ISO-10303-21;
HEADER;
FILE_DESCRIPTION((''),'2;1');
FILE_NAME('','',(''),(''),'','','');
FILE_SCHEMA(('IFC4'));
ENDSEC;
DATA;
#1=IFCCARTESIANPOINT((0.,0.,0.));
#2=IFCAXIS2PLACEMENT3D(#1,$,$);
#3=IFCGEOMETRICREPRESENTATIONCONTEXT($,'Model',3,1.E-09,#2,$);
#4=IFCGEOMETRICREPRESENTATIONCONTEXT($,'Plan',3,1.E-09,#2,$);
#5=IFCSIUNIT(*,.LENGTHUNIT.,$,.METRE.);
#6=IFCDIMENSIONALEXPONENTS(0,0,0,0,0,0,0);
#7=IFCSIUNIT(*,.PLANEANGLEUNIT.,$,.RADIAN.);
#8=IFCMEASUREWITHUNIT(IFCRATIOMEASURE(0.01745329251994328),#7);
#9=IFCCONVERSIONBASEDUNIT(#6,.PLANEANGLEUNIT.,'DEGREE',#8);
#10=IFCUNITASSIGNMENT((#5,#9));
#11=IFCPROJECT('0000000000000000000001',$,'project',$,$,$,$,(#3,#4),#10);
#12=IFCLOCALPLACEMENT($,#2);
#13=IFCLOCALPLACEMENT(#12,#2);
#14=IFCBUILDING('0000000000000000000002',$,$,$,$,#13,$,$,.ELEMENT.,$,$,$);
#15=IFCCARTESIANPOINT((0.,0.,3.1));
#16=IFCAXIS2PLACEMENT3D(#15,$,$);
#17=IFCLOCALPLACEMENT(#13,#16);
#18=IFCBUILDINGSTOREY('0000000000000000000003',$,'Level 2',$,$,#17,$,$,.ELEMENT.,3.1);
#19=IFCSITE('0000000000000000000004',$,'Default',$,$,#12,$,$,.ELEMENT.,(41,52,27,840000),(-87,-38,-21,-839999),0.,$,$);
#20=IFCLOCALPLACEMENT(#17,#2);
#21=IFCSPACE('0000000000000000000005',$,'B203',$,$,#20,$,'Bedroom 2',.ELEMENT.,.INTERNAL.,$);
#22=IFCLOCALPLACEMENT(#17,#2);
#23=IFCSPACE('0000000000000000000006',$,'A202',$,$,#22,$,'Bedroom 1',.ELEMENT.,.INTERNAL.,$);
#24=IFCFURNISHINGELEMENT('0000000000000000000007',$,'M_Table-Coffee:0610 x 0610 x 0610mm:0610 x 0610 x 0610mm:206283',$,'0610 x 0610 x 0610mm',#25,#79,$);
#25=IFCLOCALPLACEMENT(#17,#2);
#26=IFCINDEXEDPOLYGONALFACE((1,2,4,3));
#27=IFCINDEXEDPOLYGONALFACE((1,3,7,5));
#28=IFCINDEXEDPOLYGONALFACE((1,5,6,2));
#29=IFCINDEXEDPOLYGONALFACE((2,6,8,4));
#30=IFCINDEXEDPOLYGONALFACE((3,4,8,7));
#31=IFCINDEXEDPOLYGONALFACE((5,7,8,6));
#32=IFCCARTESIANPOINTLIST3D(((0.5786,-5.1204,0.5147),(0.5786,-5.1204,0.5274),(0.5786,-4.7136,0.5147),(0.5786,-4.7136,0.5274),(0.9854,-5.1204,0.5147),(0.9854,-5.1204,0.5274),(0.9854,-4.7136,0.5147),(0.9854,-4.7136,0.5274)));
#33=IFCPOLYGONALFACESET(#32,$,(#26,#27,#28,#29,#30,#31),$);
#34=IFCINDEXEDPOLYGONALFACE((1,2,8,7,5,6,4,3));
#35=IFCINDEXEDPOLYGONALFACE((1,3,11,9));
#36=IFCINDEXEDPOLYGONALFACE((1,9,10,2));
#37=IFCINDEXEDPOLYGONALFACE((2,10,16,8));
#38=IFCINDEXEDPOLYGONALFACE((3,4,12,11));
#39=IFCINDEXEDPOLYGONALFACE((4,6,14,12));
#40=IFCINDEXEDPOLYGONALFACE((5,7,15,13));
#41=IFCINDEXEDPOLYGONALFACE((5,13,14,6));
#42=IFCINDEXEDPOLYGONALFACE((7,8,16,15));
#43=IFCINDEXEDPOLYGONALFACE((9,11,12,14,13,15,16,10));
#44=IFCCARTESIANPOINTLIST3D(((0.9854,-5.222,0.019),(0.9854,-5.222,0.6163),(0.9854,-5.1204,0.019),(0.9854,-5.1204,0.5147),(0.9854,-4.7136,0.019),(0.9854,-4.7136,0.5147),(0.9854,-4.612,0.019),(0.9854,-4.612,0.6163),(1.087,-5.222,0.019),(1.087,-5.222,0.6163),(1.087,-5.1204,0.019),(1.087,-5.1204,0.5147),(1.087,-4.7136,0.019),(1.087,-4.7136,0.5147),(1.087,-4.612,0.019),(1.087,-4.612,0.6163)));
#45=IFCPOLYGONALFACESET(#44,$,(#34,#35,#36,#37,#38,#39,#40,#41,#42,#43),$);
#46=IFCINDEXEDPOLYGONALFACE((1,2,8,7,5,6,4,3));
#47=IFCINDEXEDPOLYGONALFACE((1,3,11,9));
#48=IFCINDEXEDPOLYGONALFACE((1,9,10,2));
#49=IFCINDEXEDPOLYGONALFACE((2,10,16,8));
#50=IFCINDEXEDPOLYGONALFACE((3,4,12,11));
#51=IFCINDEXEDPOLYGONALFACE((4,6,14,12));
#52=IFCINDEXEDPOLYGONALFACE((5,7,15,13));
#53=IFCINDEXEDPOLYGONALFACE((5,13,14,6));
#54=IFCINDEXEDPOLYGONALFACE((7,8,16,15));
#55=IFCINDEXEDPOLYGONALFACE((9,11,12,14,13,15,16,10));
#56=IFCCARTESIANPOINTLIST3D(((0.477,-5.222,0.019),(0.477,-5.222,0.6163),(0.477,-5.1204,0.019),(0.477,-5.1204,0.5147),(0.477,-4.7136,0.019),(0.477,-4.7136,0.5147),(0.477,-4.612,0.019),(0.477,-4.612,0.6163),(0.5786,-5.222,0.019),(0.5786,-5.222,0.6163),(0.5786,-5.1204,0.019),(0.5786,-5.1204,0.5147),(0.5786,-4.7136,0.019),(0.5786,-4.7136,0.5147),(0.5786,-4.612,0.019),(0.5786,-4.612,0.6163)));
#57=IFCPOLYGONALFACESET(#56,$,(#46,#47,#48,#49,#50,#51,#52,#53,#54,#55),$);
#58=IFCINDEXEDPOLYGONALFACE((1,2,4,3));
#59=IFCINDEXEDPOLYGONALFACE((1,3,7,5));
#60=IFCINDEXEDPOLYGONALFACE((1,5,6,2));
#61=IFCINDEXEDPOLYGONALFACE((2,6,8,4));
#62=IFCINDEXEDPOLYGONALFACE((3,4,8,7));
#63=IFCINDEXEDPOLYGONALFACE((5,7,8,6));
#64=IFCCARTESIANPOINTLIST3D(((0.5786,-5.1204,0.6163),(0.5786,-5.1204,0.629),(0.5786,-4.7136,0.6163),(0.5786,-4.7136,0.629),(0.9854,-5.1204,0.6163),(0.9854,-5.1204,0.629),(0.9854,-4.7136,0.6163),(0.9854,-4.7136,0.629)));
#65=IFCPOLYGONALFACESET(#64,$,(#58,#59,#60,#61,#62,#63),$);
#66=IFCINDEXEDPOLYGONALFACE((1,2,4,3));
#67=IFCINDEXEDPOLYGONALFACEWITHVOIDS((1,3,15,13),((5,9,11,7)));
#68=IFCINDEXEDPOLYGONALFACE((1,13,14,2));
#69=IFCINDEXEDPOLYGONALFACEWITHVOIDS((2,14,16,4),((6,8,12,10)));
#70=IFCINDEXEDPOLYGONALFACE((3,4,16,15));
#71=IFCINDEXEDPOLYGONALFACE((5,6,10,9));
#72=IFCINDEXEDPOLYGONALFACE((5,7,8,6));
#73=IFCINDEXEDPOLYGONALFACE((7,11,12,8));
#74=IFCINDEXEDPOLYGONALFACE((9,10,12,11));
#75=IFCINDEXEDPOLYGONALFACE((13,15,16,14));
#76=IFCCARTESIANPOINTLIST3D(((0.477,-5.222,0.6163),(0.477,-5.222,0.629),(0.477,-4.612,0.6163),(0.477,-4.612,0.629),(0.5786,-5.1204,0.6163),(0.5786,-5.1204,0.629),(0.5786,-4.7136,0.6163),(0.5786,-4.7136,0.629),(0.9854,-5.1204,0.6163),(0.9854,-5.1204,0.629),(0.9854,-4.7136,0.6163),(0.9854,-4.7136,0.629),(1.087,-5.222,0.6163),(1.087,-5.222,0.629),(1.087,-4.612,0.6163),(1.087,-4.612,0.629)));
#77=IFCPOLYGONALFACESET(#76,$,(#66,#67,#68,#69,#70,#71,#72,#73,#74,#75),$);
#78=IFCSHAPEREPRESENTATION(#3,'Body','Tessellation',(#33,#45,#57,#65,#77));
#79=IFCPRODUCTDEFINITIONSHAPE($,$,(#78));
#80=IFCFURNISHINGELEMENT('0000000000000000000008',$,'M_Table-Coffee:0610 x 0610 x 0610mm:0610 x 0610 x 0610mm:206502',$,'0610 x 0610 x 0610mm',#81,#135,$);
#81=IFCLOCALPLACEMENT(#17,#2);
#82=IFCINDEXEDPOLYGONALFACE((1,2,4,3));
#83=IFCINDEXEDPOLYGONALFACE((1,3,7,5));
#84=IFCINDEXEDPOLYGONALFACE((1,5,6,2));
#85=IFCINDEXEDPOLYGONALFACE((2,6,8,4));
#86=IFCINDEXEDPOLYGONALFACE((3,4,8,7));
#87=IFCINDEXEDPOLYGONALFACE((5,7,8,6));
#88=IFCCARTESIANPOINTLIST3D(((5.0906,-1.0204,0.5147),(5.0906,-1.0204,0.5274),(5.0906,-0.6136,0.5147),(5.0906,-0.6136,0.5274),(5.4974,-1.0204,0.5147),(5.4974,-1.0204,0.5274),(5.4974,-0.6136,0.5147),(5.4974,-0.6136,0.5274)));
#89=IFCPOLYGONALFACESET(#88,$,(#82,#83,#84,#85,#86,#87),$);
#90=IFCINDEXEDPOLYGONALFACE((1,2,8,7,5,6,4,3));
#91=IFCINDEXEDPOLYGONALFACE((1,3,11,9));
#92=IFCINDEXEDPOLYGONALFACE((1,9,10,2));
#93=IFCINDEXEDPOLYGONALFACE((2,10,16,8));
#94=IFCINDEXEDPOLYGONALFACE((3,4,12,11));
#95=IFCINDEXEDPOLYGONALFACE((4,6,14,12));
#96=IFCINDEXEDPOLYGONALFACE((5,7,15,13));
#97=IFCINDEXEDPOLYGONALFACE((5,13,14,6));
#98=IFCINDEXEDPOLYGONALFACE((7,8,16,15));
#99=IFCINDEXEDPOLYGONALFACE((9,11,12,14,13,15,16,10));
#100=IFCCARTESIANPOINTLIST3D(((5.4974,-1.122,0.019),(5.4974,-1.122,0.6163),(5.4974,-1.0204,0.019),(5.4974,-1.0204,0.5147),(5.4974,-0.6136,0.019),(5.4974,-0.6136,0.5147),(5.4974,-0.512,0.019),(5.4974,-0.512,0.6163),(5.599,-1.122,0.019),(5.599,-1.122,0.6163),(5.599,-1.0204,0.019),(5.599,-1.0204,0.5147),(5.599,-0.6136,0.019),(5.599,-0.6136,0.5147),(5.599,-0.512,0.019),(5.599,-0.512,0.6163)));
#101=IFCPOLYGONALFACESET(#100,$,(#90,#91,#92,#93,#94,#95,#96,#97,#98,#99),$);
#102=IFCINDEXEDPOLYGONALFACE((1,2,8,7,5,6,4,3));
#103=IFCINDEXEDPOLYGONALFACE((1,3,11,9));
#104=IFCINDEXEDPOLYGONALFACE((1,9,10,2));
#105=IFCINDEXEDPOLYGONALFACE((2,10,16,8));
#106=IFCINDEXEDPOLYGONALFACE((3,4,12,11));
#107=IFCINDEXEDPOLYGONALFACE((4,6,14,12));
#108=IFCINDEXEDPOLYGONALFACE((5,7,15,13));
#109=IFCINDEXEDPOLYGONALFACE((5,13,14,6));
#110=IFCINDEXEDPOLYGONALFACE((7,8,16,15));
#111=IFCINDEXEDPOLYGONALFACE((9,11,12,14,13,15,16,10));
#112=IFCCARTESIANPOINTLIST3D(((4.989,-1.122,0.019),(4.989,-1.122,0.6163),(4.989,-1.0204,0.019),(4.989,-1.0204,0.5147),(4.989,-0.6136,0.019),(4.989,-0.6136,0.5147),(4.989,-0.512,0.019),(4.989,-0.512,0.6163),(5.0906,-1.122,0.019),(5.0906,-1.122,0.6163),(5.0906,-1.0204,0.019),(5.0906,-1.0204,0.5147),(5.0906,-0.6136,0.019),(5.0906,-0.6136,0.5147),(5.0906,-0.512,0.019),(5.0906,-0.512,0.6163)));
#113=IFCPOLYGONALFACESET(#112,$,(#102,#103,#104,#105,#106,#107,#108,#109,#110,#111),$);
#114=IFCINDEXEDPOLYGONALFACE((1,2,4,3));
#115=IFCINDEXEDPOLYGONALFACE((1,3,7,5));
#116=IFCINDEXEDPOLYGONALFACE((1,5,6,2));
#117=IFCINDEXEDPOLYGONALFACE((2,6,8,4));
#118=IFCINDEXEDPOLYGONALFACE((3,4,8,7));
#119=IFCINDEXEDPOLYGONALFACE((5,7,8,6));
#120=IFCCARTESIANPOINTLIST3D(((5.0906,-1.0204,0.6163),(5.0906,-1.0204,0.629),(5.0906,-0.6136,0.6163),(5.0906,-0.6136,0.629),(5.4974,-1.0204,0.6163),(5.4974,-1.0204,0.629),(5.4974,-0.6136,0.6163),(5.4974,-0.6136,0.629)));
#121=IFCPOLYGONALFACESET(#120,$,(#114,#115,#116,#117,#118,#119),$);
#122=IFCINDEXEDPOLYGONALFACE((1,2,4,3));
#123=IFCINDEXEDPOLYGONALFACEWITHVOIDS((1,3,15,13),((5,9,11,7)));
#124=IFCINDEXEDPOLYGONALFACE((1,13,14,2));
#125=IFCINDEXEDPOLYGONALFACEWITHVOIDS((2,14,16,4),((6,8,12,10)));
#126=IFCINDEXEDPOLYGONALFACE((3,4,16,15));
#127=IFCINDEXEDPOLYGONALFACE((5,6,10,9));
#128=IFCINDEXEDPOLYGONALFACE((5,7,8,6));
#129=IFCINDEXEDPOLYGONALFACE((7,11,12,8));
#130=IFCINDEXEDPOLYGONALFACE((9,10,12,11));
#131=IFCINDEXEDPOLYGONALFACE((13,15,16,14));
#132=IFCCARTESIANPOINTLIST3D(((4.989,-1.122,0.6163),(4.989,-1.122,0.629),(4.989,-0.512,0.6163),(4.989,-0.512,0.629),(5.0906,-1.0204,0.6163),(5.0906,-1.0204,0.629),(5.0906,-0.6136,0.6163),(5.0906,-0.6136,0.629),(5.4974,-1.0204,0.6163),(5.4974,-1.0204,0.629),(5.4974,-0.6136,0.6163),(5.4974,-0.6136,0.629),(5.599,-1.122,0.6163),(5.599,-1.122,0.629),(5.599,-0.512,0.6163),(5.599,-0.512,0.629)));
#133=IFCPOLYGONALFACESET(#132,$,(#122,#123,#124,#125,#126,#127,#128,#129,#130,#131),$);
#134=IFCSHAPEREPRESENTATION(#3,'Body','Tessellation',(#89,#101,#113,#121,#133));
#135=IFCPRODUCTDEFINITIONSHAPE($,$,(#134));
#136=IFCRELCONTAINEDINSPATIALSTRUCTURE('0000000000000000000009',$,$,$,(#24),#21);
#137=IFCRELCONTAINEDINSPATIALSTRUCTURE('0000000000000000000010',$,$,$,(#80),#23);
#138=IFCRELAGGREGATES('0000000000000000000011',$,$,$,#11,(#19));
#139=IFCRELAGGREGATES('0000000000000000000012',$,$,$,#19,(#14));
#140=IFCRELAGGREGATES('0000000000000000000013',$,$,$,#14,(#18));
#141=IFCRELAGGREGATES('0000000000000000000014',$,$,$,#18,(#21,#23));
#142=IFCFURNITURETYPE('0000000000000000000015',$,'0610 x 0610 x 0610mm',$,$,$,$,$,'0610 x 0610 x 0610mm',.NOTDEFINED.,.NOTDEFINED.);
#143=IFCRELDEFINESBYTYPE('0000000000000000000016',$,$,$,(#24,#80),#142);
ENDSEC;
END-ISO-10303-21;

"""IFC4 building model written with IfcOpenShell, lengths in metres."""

from ifc_helpers import new_model, entity, si_unit, converted_unit, frame, origin, origin_2d_with_axis, place, context, project, spatial, polyline, rectangle, outline, extrude, source, transform, mapped, type_object, type_shapes, element, save


model = new_model("IFC4")

# Units and contexts
model_context = context("Model", 3, precision=1e-09, world=origin())
plan_context = context("Plan", 3, precision=1e-09, world=origin())
ifc_project = project(units=[si_unit("LENGTHUNIT", "METRE"), converted_unit("PLANEANGLEUNIT", "DEGREE", entity("IfcRatioMeasure", 0.01745329251994328), si_unit("PLANEANGLEUNIT", "RADIAN"), dimensions=[0, 0, 0, 0, 0, 0, 0])], contexts=[model_context, plan_context])

# Site, building, storey
site_placement = place(None, origin())
site = spatial("IfcSite", under=ifc_project, at=site_placement, Name="Default", CompositionType="ELEMENT", RefLatitude=(41, 52, 27, 840000), RefLongitude=(-87, -38, -21, -839999), RefElevation=0.0)
building_placement = place(site_placement, origin())
building = spatial("IfcBuilding", under=site, at=building_placement, CompositionType="ELEMENT")
storey_placement = place(building_placement, frame((0.0, 0.0, 3.1)))
storey = spatial("IfcBuildingStorey", under=building, at=storey_placement, Name="Level 2", CompositionType="ELEMENT", Elevation=3.1)

# Shared definitions
space_1_placement = place(storey_placement, origin())
space_1 = spatial("IfcSpace", under=storey, at=space_1_placement, Name="B203", LongName="Bedroom 2", CompositionType="ELEMENT", PredefinedType="INTERNAL")

# Furnishing element
furniture_type = type_object("IfcFurnitureType", Name="0610 x 0610 x 0610mm", ElementType="0610 x 0610 x 0610mm", AssemblyPlace="NOTDEFINED")
shared_shape_1 = source(origin(), model_context, "Body", "SweptSolid", [
    extrude(rectangle(XDim=0.4068, YDim=0.4068, at=origin_2d_with_axis()), frame((0.0183, 0.0952, 0.4957), z_axis=(0.0, 0.0, 1.0), x_axis=(-1.0, 0.0, 0.0)), (0.0, 0.0, 1.0), 0.0127),
    extrude(outline(polyline([(-0.2732, -0.305), (0.324, -0.305), (0.324, 0.305), (-0.2732, 0.305), (-0.2732, 0.2034), (0.2225, 0.2034), (0.2225, -0.2034), (-0.2732, -0.2034), (-0.2732, -0.305)])), frame((0.2217, 0.0952, 0.2732), z_axis=(1.0, 0.0, 0.0), x_axis=(0.0, 0.0, 1.0)), (0.0, 0.0, 1.0), 0.1016),
    extrude(outline(polyline([(-0.305, -0.3241), (0.305, -0.3241), (0.305, 0.2733), (0.2034, 0.2733), (0.2034, -0.2224), (-0.2034, -0.2224), (-0.2034, 0.2733), (-0.305, 0.2733), (-0.305, -0.3241)])), frame((-0.2867, 0.0952, 0.2733), z_axis=(1.0, 0.0, 0.0), x_axis=(0.0, -1.0, 0.0)), (0.0, 0.0, 1.0), 0.1016),
    extrude(rectangle(XDim=0.4068, YDim=0.4068, at=origin_2d_with_axis()), frame((0.0183, 0.0952, 0.5973), z_axis=(0.0, 0.0, 1.0), x_axis=(-1.0, 0.0, 0.0)), (0.0, 0.0, 1.0), 0.0127),
    extrude(outline(polyline([(-0.305, -0.305), (0.305, -0.305), (0.305, 0.305), (-0.305, 0.305), (-0.305, -0.305)]), holes=[polyline([(-0.2034, -0.2034), (-0.2034, 0.2034), (0.2034, 0.2034), (0.2034, -0.2034), (-0.2034, -0.2034)])]), frame((0.0183, 0.0952, 0.5973), z_axis=(0.0, 0.0, 1.0), x_axis=(-1.0, 0.0, 0.0)), (0.0, 0.0, 1.0), 0.0127),
])
type_shapes(furniture_type, [shared_shape_1])
furnishing_1_placement = place(space_1_placement, frame((0.7637, -5.0122, 0.019)))
element("IfcFurnishingElement", 1, at=furnishing_1_placement, inside=space_1, type_object=furniture_type, Name="M_Table-Coffee:0610 x 0610 x 0610mm:0610 x 0610 x 0610mm:206283", ObjectType="0610 x 0610 x 0610mm", context=model_context, shape_type="MappedRepresentation", body=[
    mapped(shared_shape_1, transform((0.0, 0.0, 0.0), scale=1.0)),
])

# Shared definitions
space_2_placement = place(storey_placement, origin())
space_2 = spatial("IfcSpace", under=storey, at=space_2_placement, Name="A202", LongName="Bedroom 1", CompositionType="ELEMENT", PredefinedType="INTERNAL")

# Furnishing element
furnishing_2_placement = place(space_2_placement, frame((5.2757, -0.9122, 0.019)))
element("IfcFurnishingElement", 2, at=furnishing_2_placement, inside=space_2, type_object=furniture_type, Name="M_Table-Coffee:0610 x 0610 x 0610mm:0610 x 0610 x 0610mm:206502", ObjectType="0610 x 0610 x 0610mm", context=model_context, shape_type="MappedRepresentation", body=[
    mapped(shared_shape_1, transform((0.0, 0.0, 0.0), scale=1.0)),
])

save(model, "model.ifc")
